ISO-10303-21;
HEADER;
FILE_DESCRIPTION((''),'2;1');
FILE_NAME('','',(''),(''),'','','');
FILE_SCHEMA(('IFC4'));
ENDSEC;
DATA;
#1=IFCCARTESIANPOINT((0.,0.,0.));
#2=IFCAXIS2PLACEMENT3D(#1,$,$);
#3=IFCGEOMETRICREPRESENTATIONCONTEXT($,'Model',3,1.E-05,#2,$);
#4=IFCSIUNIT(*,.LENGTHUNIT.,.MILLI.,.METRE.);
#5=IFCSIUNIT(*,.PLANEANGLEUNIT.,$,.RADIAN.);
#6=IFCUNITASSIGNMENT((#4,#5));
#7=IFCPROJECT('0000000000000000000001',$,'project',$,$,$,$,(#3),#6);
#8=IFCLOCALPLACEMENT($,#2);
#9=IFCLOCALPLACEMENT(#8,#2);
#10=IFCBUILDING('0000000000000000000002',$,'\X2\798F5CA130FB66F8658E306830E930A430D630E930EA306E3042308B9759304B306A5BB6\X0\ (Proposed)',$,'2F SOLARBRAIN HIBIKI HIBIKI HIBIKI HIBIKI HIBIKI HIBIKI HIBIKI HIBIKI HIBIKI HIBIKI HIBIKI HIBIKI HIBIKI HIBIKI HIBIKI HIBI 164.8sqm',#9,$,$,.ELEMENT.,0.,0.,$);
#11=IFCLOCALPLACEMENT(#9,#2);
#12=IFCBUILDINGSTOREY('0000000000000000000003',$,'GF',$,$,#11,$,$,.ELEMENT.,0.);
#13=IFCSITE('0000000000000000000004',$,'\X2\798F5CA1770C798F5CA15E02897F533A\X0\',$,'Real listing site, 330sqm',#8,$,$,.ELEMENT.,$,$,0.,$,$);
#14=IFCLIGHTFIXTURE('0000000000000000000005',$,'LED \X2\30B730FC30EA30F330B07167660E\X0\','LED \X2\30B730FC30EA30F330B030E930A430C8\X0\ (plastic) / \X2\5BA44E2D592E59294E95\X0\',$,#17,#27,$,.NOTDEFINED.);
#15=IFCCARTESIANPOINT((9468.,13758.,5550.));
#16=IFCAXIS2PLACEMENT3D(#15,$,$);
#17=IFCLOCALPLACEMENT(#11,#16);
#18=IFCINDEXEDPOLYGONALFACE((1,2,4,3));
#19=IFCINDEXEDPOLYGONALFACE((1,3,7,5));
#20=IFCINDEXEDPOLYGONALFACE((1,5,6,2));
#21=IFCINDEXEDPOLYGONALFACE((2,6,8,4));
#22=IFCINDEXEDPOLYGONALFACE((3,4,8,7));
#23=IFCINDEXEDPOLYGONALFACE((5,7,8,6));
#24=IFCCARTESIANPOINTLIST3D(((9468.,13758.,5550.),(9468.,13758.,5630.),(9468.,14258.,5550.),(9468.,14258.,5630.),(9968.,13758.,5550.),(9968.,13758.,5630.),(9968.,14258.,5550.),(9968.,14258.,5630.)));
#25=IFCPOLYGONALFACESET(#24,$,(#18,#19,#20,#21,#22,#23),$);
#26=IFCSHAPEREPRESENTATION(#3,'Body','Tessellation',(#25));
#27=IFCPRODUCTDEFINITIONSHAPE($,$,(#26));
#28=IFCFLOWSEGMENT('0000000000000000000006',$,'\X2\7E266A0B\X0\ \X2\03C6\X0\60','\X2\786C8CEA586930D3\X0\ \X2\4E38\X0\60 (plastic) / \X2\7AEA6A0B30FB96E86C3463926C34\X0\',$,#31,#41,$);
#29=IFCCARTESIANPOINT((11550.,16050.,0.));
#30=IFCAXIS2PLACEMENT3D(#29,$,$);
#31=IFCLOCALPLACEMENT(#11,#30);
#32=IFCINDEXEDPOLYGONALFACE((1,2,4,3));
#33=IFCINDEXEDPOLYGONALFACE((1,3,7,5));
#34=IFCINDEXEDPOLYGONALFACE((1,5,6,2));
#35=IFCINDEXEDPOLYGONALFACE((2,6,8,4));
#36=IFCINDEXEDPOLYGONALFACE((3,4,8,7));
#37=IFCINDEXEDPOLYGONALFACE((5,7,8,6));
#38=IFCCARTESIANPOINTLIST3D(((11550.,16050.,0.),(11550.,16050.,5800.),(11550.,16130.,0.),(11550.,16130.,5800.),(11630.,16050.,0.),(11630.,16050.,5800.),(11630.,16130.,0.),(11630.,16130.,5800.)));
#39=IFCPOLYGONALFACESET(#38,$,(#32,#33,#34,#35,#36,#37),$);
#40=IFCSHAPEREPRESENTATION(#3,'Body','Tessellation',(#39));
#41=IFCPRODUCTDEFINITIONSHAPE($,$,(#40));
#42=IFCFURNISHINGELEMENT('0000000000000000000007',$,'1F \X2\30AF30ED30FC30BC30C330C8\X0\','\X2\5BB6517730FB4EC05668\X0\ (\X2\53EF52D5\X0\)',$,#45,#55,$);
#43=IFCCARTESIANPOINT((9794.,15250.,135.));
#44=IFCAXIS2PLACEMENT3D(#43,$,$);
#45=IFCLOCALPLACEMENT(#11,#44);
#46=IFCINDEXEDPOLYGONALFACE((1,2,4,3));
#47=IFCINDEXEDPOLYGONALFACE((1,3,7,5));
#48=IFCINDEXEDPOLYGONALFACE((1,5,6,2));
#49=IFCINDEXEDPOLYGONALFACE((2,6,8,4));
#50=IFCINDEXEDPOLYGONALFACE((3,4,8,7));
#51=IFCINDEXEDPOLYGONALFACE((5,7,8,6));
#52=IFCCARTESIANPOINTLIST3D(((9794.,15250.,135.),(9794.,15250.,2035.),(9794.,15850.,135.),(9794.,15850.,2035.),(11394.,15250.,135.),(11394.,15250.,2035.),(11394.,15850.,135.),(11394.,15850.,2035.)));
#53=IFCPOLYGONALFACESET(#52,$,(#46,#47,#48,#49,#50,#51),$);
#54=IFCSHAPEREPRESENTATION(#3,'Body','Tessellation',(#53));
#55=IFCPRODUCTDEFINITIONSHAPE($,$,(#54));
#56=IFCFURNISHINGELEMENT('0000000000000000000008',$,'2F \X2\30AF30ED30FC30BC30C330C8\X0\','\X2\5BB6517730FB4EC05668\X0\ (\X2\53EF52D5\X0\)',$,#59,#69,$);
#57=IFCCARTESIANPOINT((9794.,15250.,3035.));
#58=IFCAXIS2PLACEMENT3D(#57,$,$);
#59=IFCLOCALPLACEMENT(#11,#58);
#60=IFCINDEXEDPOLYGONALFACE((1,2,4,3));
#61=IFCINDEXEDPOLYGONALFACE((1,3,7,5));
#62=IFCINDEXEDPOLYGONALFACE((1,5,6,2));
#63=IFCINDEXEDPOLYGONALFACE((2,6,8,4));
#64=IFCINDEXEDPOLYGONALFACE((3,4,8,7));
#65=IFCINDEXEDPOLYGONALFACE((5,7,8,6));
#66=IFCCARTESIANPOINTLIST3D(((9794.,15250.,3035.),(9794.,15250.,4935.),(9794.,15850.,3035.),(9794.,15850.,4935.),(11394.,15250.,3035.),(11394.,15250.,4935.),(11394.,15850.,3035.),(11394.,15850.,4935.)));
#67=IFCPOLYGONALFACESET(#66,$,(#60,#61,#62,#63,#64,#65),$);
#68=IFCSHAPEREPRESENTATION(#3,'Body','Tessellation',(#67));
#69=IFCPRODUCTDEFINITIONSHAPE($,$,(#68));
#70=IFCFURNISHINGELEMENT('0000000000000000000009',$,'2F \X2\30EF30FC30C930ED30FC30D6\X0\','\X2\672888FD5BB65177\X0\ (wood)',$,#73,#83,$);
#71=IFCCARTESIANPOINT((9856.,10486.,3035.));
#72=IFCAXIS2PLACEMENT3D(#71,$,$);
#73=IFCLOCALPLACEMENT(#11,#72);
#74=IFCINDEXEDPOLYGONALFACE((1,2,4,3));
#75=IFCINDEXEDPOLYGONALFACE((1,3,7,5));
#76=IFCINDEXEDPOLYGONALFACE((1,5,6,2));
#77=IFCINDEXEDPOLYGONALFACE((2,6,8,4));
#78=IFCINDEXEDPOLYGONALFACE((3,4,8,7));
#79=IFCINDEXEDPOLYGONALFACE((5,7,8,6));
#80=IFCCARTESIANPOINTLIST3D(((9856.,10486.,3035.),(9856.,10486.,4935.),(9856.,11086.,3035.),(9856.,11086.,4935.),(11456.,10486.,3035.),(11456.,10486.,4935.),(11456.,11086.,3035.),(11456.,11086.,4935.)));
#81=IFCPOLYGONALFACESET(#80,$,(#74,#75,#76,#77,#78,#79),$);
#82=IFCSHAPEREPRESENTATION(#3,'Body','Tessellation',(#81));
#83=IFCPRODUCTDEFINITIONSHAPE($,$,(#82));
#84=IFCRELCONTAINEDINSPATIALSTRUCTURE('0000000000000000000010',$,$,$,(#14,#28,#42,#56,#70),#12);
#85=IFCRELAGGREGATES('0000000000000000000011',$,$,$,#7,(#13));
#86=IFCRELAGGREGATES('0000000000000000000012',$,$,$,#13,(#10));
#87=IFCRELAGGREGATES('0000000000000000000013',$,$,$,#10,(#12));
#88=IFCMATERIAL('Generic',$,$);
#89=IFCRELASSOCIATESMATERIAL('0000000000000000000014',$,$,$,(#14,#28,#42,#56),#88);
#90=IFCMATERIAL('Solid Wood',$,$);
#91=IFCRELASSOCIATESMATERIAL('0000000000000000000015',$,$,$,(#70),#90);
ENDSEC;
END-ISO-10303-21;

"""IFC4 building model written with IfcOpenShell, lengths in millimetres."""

from ifc_helpers import new_model, si_unit, frame, frame_2d, origin, place, context, project, spatial, rectangle, extrude, material, element, save


model = new_model("IFC4")

# Units and contexts
model_context = context("Model", 3, precision=1e-05, world=origin())
ifc_project = project(units=[si_unit("LENGTHUNIT", "METRE", prefix="MILLI"), si_unit("PLANEANGLEUNIT", "RADIAN")], contexts=[model_context])

# Site, building, storey
site_placement = place(None, origin())
site = spatial("IfcSite", under=ifc_project, at=site_placement, Name="福岡県福岡市西区", ObjectType="Real listing site, 330sqm", CompositionType="ELEMENT", RefElevation=0.0)
building_placement = place(site_placement, origin())
building = spatial("IfcBuilding", under=site, at=building_placement, Name="福岡・書斎とライブラリのある静かな家 (Proposed)", ObjectType="2F SOLARBRAIN HIBIKI HIBIKI HIBIKI HIBIKI HIBIKI HIBIKI HIBIKI HIBIKI HIBIKI HIBIKI HIBIKI HIBIKI HIBIKI HIBIKI HIBIKI HIBI 164.8sqm", CompositionType="ELEMENT", ElevationOfRefHeight=0.0, ElevationOfTerrain=0.0)
storey_placement = place(building_placement, origin())
storey = spatial("IfcBuildingStorey", under=building, at=storey_placement, Name="GF", CompositionType="ELEMENT", Elevation=0.0)

# Shared definitions
ifc_material_1 = material(Name="Solid Wood")

# Shared definitions
ifc_material_2 = material(Name="Generic")

# Light fixture
light_fixture_1_placement = place(storey_placement, frame((9468.0, 13758.0, 5550.0)))
element("IfcLightFixture", 1, at=light_fixture_1_placement, inside=storey, material=ifc_material_2, Name="LED シーリング照明", Description="LED シーリングライト (plastic) / 室中央天井", PredefinedType="NOTDEFINED", context=model_context, shape_type="SweptSolid", body=[
    extrude(rectangle(XDim=500.0, YDim=500.0, at=frame_2d((250.0, 250.0))), frame((9468.0, 13758.0, 5550.0)), (0.0, 0.0, 1.0), 80.0),
])

# Flow segment
flow_segment_placement = place(storey_placement, frame((11550.0, 16050.0, 0.0)))
element("IfcFlowSegment", 2, at=flow_segment_placement, inside=storey, material=ifc_material_2, Name="縦樋 φ60", Description="硬質塩ビ 丸60 (plastic) / 竪樋・雨水排水", context=model_context, shape_type="SweptSolid", body=[
    extrude(rectangle(XDim=80.0, YDim=80.0, at=frame_2d((40.0, 40.0))), frame((11550.0, 16050.0, 0.0)), (0.0, 0.0, 1.0), 5800.0),
])

# Furnishing elements
furnishing_1_placement = place(storey_placement, frame((9794.0, 15250.0, 135.0)))
element("IfcFurnishingElement", 3, at=furnishing_1_placement, inside=storey, material=ifc_material_2, Name="1F クローゼット", Description="家具・什器 (可動)", context=model_context, shape_type="SweptSolid", body=[
    extrude(rectangle(XDim=1600.0, YDim=600.0, at=frame_2d((800.0, 300.0))), frame((9794.0, 15250.0, 135.0)), (0.0, 0.0, 1.0), 1900.0),
])
furnishing_2_placement = place(storey_placement, frame((9794.0, 15250.0, 3035.0)))
element("IfcFurnishingElement", 4, at=furnishing_2_placement, inside=storey, material=ifc_material_2, Name="2F クローゼット", Description="家具・什器 (可動)", context=model_context, shape_type="SweptSolid", body=[
    extrude(rectangle(XDim=1600.0, YDim=600.0, at=frame_2d((800.0, 300.0))), frame((9794.0, 15250.0, 3035.0)), (0.0, 0.0, 1.0), 1900.0),
])
furnishing_3_placement = place(storey_placement, frame((9856.0, 10486.0, 3035.0)))
element("IfcFurnishingElement", 5, at=furnishing_3_placement, inside=storey, material=ifc_material_1, Name="2F ワードローブ", Description="木製家具 (wood)", context=model_context, shape_type="SweptSolid", body=[
    extrude(rectangle(XDim=1600.0, YDim=600.0, at=frame_2d((800.0, 300.0))), frame((9856.0, 10486.0, 3035.0)), (0.0, 0.0, 1.0), 1900.0),
])

save(model, "model.ifc")
